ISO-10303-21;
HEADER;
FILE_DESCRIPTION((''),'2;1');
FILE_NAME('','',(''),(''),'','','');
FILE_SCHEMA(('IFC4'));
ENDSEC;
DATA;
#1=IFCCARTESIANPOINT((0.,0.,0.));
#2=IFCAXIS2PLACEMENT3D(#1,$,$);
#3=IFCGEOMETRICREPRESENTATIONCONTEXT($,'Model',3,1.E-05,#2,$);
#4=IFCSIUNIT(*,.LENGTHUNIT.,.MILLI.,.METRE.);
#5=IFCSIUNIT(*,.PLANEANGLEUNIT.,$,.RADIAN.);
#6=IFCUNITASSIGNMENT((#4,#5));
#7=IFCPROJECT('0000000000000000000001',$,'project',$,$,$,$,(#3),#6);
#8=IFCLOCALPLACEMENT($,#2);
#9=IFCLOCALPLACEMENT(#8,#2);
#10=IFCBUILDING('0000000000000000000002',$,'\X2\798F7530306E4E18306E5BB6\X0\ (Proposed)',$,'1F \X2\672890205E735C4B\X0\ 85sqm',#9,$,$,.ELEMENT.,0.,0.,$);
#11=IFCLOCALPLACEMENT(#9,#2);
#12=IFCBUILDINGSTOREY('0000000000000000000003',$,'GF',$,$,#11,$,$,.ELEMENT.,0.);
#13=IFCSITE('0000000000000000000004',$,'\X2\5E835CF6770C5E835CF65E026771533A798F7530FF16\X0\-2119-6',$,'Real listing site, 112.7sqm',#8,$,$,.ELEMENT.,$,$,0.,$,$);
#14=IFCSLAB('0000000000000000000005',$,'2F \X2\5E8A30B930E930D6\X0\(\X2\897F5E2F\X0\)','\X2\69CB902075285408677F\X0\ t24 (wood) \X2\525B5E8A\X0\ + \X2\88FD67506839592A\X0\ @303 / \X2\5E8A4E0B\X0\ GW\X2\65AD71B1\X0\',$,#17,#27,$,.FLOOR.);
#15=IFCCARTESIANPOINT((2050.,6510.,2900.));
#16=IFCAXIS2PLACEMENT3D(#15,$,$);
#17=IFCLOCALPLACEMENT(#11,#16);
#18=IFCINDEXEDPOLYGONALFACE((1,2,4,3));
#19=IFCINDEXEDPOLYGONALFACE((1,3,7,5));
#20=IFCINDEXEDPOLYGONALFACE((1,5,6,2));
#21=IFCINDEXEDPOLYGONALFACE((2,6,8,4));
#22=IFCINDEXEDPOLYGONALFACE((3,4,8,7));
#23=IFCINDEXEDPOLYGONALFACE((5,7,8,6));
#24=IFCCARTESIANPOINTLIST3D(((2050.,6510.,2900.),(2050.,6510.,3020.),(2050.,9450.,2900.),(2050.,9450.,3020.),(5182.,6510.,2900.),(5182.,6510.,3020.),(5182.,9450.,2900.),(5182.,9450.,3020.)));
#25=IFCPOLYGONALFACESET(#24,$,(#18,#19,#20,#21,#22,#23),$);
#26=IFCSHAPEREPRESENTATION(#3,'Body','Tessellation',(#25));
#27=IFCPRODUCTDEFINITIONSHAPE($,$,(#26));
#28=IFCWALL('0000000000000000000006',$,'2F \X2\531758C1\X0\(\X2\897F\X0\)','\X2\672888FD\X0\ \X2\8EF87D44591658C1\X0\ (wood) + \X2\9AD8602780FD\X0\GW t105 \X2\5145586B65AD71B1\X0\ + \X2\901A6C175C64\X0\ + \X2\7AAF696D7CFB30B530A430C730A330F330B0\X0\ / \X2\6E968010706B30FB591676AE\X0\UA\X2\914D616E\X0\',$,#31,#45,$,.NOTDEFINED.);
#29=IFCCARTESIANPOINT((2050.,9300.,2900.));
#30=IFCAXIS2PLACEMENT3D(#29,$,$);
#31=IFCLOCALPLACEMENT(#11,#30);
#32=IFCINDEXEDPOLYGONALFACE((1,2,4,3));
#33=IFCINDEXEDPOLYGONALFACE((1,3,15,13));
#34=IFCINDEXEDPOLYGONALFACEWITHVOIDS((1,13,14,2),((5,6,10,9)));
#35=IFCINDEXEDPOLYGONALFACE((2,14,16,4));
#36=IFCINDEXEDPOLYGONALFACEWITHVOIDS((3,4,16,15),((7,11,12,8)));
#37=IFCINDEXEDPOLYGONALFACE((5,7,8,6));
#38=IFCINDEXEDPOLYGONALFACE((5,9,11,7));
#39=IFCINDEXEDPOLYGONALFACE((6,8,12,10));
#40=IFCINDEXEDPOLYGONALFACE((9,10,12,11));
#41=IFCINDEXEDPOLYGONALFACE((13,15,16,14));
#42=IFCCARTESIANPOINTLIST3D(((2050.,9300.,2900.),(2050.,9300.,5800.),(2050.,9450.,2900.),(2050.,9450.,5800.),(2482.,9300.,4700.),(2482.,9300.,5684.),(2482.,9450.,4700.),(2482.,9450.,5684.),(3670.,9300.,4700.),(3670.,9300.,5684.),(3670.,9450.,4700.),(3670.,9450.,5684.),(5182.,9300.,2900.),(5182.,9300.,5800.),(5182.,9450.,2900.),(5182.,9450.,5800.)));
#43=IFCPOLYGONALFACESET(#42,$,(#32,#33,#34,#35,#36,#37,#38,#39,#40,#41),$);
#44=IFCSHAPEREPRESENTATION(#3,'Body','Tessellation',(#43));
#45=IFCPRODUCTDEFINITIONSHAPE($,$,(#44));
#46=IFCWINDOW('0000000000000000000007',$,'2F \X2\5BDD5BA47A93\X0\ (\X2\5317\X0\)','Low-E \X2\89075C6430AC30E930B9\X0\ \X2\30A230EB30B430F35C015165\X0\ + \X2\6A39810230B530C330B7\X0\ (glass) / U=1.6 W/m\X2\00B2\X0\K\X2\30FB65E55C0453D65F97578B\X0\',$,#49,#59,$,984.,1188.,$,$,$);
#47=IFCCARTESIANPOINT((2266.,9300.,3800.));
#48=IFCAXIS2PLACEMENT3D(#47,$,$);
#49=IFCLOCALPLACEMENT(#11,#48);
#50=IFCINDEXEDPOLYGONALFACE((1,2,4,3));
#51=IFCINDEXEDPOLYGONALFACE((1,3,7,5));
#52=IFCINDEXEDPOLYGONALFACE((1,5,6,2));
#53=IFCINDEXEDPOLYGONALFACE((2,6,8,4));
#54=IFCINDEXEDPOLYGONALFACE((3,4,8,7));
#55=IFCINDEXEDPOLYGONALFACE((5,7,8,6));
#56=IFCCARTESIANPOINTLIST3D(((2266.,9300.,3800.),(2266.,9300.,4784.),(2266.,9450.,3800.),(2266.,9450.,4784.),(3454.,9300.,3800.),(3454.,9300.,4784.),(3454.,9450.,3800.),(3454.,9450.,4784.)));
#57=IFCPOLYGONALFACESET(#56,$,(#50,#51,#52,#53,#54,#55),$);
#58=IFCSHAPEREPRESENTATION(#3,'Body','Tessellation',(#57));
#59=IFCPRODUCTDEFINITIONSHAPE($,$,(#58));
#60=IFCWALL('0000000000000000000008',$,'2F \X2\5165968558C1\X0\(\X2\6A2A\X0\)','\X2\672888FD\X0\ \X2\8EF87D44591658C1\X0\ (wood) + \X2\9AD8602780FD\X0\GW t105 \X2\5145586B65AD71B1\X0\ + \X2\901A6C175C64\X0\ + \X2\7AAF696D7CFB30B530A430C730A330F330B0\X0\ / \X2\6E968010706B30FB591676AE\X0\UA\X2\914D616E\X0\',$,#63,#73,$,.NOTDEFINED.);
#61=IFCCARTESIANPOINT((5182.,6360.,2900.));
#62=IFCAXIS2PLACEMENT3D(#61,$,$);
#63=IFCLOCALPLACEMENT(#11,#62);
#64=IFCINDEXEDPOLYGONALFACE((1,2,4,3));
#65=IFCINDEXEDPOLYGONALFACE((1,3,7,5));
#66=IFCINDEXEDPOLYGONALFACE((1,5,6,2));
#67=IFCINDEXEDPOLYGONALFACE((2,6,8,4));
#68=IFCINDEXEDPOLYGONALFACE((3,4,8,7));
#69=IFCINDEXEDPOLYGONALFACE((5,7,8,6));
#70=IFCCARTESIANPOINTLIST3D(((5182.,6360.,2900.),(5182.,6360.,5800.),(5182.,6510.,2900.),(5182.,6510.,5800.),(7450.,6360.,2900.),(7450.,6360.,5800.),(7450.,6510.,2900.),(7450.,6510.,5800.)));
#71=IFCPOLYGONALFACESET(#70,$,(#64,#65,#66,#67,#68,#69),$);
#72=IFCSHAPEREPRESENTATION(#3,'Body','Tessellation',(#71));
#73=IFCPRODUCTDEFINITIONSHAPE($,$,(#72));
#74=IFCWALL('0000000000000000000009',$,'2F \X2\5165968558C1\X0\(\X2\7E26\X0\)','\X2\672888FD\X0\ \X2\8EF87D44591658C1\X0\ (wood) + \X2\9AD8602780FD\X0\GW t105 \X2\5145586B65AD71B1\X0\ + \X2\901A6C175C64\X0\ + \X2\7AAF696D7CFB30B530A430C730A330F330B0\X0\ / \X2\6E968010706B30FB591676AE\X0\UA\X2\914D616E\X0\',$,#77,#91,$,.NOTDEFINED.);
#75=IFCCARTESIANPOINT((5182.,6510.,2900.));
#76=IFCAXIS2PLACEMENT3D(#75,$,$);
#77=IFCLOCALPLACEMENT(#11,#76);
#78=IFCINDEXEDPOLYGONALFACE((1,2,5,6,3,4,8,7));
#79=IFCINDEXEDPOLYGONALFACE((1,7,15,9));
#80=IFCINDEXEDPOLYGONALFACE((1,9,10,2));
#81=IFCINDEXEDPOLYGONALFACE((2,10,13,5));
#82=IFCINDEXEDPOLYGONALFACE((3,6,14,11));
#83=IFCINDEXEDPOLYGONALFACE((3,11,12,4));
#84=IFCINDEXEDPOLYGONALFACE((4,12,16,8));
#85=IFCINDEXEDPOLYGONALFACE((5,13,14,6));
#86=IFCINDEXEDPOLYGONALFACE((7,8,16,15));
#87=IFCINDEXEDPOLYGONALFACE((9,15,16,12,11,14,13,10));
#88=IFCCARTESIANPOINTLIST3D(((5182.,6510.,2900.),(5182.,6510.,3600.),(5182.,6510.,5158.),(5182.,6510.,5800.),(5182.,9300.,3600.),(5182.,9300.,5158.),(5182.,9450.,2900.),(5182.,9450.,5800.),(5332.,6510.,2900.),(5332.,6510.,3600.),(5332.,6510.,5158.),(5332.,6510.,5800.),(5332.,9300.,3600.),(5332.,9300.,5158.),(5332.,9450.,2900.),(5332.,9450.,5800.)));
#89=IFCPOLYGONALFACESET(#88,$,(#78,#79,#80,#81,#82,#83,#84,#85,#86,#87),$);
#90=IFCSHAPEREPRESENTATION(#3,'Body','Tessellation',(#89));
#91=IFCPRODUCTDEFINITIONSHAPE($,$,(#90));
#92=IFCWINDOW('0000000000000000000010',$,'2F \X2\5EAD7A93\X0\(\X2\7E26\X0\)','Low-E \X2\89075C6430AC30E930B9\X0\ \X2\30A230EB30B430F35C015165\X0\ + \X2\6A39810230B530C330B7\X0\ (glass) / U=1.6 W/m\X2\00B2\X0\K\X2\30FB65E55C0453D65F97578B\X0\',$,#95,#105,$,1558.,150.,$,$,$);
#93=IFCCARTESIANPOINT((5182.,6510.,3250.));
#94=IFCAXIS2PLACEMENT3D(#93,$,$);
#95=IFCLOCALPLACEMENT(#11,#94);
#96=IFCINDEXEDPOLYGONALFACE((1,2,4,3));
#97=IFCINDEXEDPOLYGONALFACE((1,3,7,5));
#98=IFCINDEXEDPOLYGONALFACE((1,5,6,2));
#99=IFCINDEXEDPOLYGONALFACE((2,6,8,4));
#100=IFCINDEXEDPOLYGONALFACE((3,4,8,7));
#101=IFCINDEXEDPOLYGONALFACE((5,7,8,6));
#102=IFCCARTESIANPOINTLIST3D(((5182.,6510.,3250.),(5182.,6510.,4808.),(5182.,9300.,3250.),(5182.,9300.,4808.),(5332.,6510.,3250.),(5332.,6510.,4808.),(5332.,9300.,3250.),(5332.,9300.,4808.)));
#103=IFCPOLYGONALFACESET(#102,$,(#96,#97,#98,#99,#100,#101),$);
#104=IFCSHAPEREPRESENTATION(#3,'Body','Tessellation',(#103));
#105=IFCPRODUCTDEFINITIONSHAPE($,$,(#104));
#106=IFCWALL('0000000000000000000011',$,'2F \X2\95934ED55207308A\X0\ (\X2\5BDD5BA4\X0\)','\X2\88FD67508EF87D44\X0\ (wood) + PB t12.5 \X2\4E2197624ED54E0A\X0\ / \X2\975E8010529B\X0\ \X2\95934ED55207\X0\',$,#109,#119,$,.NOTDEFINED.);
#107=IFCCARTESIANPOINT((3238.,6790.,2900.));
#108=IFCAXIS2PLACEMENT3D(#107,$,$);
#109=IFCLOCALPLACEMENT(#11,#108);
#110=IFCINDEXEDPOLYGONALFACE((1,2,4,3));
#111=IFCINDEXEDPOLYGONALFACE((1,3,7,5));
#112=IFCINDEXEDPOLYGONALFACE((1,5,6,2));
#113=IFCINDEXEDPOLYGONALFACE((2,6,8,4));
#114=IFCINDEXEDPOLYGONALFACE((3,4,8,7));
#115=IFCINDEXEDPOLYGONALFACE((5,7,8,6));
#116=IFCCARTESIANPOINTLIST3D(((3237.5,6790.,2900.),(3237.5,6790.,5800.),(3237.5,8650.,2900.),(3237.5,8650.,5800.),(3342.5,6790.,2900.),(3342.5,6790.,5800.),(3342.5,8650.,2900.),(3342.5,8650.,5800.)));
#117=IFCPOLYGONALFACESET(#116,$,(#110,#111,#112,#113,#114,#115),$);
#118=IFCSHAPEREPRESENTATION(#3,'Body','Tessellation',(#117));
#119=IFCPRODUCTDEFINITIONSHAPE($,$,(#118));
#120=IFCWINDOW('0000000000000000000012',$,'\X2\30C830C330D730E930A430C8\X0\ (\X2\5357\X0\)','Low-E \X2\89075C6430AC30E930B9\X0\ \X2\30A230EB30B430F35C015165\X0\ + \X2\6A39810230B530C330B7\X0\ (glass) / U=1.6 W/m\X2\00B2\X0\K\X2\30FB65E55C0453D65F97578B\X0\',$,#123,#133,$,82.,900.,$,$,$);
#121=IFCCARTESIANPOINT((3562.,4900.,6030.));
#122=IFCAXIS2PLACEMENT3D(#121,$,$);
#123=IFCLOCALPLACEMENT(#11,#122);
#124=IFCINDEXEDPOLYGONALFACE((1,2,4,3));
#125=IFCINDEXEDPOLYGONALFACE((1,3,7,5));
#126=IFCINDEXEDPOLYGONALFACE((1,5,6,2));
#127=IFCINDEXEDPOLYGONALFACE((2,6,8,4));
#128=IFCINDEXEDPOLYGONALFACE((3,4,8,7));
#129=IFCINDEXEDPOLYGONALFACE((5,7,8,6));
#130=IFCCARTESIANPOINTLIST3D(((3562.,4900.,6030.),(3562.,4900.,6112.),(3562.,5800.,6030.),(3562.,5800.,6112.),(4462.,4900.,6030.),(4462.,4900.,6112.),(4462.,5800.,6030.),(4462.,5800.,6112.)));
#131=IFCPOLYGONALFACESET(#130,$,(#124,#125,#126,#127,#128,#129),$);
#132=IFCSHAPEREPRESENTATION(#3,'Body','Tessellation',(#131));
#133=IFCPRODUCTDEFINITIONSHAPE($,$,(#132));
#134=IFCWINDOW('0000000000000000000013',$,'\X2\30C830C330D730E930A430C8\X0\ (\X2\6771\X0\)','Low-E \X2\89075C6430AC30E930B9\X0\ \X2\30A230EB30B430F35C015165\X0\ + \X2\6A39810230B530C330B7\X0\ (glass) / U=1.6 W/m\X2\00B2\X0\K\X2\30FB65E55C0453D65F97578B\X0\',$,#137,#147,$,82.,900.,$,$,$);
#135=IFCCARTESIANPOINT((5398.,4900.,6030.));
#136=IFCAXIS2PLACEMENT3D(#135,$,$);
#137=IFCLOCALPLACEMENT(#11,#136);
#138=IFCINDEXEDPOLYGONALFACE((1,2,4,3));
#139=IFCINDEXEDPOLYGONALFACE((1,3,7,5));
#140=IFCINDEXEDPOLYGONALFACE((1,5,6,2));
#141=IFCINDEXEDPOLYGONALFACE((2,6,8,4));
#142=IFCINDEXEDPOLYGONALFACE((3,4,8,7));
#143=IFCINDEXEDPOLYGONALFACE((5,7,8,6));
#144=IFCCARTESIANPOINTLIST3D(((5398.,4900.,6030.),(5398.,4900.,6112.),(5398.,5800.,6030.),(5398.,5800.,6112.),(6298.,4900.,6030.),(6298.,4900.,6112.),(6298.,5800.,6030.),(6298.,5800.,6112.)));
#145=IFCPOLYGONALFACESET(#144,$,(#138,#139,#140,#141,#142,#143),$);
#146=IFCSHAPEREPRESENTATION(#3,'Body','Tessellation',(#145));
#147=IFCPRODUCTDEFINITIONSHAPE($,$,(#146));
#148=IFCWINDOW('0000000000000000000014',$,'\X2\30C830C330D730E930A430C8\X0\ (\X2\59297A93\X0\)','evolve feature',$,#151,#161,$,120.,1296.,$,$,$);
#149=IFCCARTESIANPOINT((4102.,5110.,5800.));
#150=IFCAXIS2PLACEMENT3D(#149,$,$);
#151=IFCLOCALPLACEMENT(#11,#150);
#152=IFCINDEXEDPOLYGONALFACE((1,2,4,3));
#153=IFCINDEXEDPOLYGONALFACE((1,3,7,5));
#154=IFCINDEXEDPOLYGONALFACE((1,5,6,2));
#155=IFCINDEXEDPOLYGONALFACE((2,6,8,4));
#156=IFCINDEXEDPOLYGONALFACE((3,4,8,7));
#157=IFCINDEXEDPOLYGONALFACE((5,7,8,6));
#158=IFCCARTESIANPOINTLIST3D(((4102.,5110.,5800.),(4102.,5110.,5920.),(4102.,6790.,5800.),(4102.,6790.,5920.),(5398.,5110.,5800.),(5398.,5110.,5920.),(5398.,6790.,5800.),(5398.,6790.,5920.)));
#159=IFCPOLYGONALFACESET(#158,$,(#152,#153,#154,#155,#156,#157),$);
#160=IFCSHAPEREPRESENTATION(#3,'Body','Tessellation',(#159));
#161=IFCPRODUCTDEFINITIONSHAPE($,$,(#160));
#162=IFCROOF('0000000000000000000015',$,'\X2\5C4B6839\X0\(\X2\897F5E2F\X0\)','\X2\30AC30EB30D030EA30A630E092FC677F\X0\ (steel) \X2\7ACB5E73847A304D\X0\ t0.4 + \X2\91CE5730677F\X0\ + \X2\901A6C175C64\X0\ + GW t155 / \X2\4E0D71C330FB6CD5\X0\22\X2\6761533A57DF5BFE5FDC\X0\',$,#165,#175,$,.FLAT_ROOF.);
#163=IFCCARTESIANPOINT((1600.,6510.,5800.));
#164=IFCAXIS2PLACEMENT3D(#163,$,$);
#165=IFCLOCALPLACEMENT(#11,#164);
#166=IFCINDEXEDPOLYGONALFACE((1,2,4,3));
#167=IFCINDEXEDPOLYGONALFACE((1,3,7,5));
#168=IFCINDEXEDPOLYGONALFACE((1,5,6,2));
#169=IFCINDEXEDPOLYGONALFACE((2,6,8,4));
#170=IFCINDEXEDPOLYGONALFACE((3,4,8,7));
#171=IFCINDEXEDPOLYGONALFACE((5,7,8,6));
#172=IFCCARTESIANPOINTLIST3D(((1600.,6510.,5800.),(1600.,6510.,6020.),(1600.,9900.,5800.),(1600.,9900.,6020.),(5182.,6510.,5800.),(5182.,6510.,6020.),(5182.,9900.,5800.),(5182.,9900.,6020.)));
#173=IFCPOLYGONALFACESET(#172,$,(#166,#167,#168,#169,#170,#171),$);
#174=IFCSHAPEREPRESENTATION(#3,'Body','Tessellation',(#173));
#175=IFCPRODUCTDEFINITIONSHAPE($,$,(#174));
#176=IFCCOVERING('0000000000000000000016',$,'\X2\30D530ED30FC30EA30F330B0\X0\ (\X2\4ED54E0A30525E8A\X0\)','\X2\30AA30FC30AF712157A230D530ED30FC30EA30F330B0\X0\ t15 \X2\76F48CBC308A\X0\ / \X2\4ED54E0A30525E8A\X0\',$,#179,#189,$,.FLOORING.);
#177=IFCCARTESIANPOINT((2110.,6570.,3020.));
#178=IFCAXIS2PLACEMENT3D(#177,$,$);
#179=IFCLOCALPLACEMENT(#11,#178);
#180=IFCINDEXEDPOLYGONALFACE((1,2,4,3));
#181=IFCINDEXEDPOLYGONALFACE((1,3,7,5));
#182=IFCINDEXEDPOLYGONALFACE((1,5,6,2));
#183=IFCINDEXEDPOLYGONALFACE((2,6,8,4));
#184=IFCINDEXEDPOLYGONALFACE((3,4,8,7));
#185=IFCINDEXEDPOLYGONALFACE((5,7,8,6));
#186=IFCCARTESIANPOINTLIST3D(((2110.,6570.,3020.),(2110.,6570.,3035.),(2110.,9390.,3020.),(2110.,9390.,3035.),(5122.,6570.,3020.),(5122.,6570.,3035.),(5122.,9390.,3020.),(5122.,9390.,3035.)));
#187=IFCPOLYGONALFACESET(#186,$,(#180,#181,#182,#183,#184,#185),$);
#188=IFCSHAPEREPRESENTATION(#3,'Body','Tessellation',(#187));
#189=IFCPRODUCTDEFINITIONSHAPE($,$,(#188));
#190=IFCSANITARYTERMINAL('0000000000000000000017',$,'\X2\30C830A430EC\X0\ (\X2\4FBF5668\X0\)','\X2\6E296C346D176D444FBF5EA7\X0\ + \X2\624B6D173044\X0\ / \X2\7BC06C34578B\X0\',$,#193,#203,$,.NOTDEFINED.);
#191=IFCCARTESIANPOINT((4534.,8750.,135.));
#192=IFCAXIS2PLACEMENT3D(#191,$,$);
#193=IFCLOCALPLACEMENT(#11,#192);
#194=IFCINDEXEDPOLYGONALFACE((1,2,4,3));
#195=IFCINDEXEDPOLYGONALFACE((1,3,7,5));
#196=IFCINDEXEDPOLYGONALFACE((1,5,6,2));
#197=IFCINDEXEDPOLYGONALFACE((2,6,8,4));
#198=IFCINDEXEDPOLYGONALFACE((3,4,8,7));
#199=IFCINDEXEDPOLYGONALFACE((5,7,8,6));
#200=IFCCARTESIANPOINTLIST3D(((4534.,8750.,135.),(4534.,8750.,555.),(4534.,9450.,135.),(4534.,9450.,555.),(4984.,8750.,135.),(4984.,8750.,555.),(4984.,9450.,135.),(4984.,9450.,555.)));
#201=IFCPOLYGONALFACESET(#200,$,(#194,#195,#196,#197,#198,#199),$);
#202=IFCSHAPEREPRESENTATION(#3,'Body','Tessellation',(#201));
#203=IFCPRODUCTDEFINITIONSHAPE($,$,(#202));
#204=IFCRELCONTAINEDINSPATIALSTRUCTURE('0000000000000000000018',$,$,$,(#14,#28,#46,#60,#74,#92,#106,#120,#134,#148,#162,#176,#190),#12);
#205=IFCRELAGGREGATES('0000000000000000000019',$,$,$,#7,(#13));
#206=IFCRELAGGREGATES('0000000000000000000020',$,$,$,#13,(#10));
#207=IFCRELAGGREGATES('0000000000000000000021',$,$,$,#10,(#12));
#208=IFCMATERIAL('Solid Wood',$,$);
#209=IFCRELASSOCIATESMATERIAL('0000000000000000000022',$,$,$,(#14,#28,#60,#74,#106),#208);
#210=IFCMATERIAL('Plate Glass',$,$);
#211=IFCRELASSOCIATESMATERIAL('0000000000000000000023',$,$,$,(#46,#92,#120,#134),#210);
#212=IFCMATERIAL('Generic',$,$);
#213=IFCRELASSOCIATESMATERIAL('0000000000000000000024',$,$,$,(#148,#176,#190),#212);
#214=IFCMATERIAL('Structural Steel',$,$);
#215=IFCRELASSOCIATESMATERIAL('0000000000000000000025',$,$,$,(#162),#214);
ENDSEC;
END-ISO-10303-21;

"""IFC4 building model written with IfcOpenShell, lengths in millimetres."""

from ifc_helpers import new_model, si_unit, frame, frame_2d, origin, place, context, project, spatial, rectangle, extrude, material, element, fill, save


model = new_model("IFC4")

# Units and contexts
model_context = context("Model", 3, precision=1e-05, world=origin())
ifc_project = project(units=[si_unit("LENGTHUNIT", "METRE", prefix="MILLI"), si_unit("PLANEANGLEUNIT", "RADIAN")], contexts=[model_context])

# Site, building, storey
site_placement = place(None, origin())
site = spatial("IfcSite", under=ifc_project, at=site_placement, Name="広島県広島市東区福田６-2119-6", ObjectType="Real listing site, 112.7sqm", CompositionType="ELEMENT", RefElevation=0.0)
building_placement = place(site_placement, origin())
building = spatial("IfcBuilding", under=site, at=building_placement, Name="福田の丘の家 (Proposed)", ObjectType="1F 木造平屋 85sqm", CompositionType="ELEMENT", ElevationOfRefHeight=0.0, ElevationOfTerrain=0.0)
storey_placement = place(building_placement, origin())
storey = spatial("IfcBuildingStorey", under=building, at=storey_placement, Name="GF", CompositionType="ELEMENT", Elevation=0.0)

# Slab
ifc_material_1 = material(Name="Solid Wood")
slab_placement = place(storey_placement, frame((2050.0, 6510.0, 2900.0)))
element("IfcSlab", 1, at=slab_placement, inside=storey, material=ifc_material_1, Name="2F 床スラブ(西帯)", Description="構造用合板 t24 (wood) 剛床 + 製材根太 @303 / 床下 GW断熱", PredefinedType="FLOOR", context=model_context, shape_type="SweptSolid", body=[
    extrude(rectangle(XDim=3132.0, YDim=2940.0, at=frame_2d((1566.0, 1470.0))), frame((2050.0, 6510.0, 2900.0)), (0.0, 0.0, 1.0), 120.0),
])

# Wall, opening, window
wall_1_placement = place(storey_placement, frame((2050.0, 9300.0, 2900.0)))
wall_1 = element("IfcWall", 2, at=wall_1_placement, inside=storey, material=ifc_material_1, Name="2F 北壁(西)", Description="木製 軸組外壁 (wood) + 高性能GW t105 充填断熱 + 通気層 + 窯業系サイディング / 準耐火・外皮UA配慮", PredefinedType="NOTDEFINED", context=model_context, shape_type="SweptSolid", body=[
    extrude(rectangle(XDim=3132.0, YDim=150.0, at=frame_2d((1566.0, 75.0))), frame((2050.0, 9300.0, 2900.0)), (0.0, 0.0, 1.0), 2900.0),
])
opening_1_placement = place(storey_placement, frame((2266.0, 9300.0, 3800.0)))
opening_1 = element("IfcOpeningElement", 3, at=opening_1_placement, cuts=wall_1, PredefinedType="NOTDEFINED", context=model_context, shape_type="SweptSolid", body=[
    extrude(rectangle(XDim=1188.0, YDim=150.0, at=frame_2d((594.0, 75.0))), frame((2266.0, 9300.0, 3800.0)), (0.0, 0.0, 1.0), 984.0),
])
ifc_material_2 = material(Name="Plate Glass")
window_1_placement = place(storey_placement, frame((2266.0, 9300.0, 3800.0)))
window_1 = element("IfcWindow", 4, at=window_1_placement, inside=storey, material=ifc_material_2, Name="2F 寝室窓 (北)", Description="Low-E 複層ガラス アルゴン封入 + 樹脂サッシ (glass) / U=1.6 W/m²K・日射取得型", OverallHeight=984.0, OverallWidth=1188.0, context=model_context, shape_type="SweptSolid", body=[
    extrude(rectangle(XDim=1188.0, YDim=150.0, at=frame_2d((594.0, 75.0))), frame((2266.0, 9300.0, 3800.0)), (0.0, 0.0, 1.0), 984.0),
])
fill(opening_1, window_1)

# Wall
wall_2_placement = place(storey_placement, frame((5182.0, 6360.0, 2900.0)))
element("IfcWall", 5, at=wall_2_placement, inside=storey, material=ifc_material_1, Name="2F 入隅壁(横)", Description="木製 軸組外壁 (wood) + 高性能GW t105 充填断熱 + 通気層 + 窯業系サイディング / 準耐火・外皮UA配慮", PredefinedType="NOTDEFINED", context=model_context, shape_type="SweptSolid", body=[
    extrude(rectangle(XDim=2268.0, YDim=150.0, at=frame_2d((1134.0, 75.0))), frame((5182.0, 6360.0, 2900.0)), (0.0, 0.0, 1.0), 2900.0),
])

# Wall, opening, window
wall_3_placement = place(storey_placement, frame((5182.0, 6510.0, 2900.0)))
wall_3 = element("IfcWall", 6, at=wall_3_placement, inside=storey, material=ifc_material_1, Name="2F 入隅壁(縦)", Description="木製 軸組外壁 (wood) + 高性能GW t105 充填断熱 + 通気層 + 窯業系サイディング / 準耐火・外皮UA配慮", PredefinedType="NOTDEFINED", context=model_context, shape_type="SweptSolid", body=[
    extrude(rectangle(XDim=150.0, YDim=2940.0, at=frame_2d((75.0, 1470.0))), frame((5182.0, 6510.0, 2900.0)), (0.0, 0.0, 1.0), 2900.0),
])
opening_2_placement = place(storey_placement, frame((5182.0, 6510.0, 3250.0)))
opening_2 = element("IfcOpeningElement", 7, at=opening_2_placement, cuts=wall_3, PredefinedType="NOTDEFINED", context=model_context, shape_type="SweptSolid", body=[
    extrude(rectangle(XDim=150.0, YDim=2790.0, at=frame_2d((75.0, 1395.0))), frame((5182.0, 6510.0, 3250.0)), (0.0, 0.0, 1.0), 1558.0),
])
window_2_placement = place(storey_placement, frame((5182.0, 6510.0, 3250.0)))
window_2 = element("IfcWindow", 8, at=window_2_placement, inside=storey, material=ifc_material_2, Name="2F 庭窓(縦)", Description="Low-E 複層ガラス アルゴン封入 + 樹脂サッシ (glass) / U=1.6 W/m²K・日射取得型", OverallHeight=1558.0, OverallWidth=150.0, context=model_context, shape_type="SweptSolid", body=[
    extrude(rectangle(XDim=150.0, YDim=2790.0, at=frame_2d((75.0, 1395.0))), frame((5182.0, 6510.0, 3250.0)), (0.0, 0.0, 1.0), 1558.0),
])
fill(opening_2, window_2)

# Wall
wall_4_placement = place(storey_placement, frame((3238.0, 6790.0, 2900.0)))
element("IfcWall", 9, at=wall_4_placement, inside=storey, material=ifc_material_1, Name="2F 間仕切り (寝室)", Description="製材軸組 (wood) + PB t12.5 両面仕上 / 非耐力 間仕切", PredefinedType="NOTDEFINED", context=model_context, shape_type="SweptSolid", body=[
    extrude(rectangle(XDim=105.0, YDim=1860.0, at=frame_2d((52.0, 930.0))), frame((3238.0, 6790.0, 2900.0)), (0.0, 0.0, 1.0), 2900.0),
])

# Windows
window_3_placement = place(storey_placement, frame((3562.0, 4900.0, 6030.0)))
element("IfcWindow", 10, at=window_3_placement, inside=storey, material=ifc_material_2, Name="トップライト (南)", Description="Low-E 複層ガラス アルゴン封入 + 樹脂サッシ (glass) / U=1.6 W/m²K・日射取得型", OverallHeight=82.0, OverallWidth=900.0, context=model_context, shape_type="SweptSolid", body=[
    extrude(rectangle(XDim=900.0, YDim=900.0, at=frame_2d((450.0, 450.0))), frame((3562.0, 4900.0, 6030.0)), (0.0, 0.0, 1.0), 82.0),
])
window_4_placement = place(storey_placement, frame((5398.0, 4900.0, 6030.0)))
element("IfcWindow", 11, at=window_4_placement, inside=storey, material=ifc_material_2, Name="トップライト (東)", Description="Low-E 複層ガラス アルゴン封入 + 樹脂サッシ (glass) / U=1.6 W/m²K・日射取得型", OverallHeight=82.0, OverallWidth=900.0, context=model_context, shape_type="SweptSolid", body=[
    extrude(rectangle(XDim=900.0, YDim=900.0, at=frame_2d((450.0, 450.0))), frame((5398.0, 4900.0, 6030.0)), (0.0, 0.0, 1.0), 82.0),
])
ifc_material_3 = material(Name="Generic")
window_5_placement = place(storey_placement, frame((4102.0, 5110.0, 5800.0)))
element("IfcWindow", 12, at=window_5_placement, inside=storey, material=ifc_material_3, Name="トップライト (天窓)", Description="evolve feature", OverallHeight=120.0, OverallWidth=1296.0, context=model_context, shape_type="SweptSolid", body=[
    extrude(rectangle(XDim=1296.0, YDim=1680.0, at=frame_2d((648.0, 840.0))), frame((4102.0, 5110.0, 5800.0)), (0.0, 0.0, 1.0), 120.0),
])

# Roof
ifc_material_4 = material(Name="Structural Steel")
for number, where, name in (
    (13, (1600.0, 6510.0, 5800.0), "屋根(西帯)"),
):
    element("IfcRoof", number, at=place(storey_placement, frame(where)), inside=storey, material=ifc_material_4, Name=name, Description="ガルバリウム鋼板 (steel) 立平葺き t0.4 + 野地板 + 通気層 + GW t155 / 不燃・法22条区域対応", PredefinedType="FLAT_ROOF", context=model_context, shape_type="SweptSolid", body=[
        extrude(rectangle(XDim=3582.0, YDim=3390.0, at=frame_2d((1791.0, 1695.0))), frame((1600.0, 6510.0, 5800.0)), (0.0, 0.0, 1.0), 220.0),
    ])

# Covering
covering_placement = place(storey_placement, frame((2110.0, 6570.0, 3020.0)))
element("IfcCovering", 14, at=covering_placement, inside=storey, material=ifc_material_3, Name="フローリング (仕上げ床)", Description="オーク無垢フローリング t15 直貼り / 仕上げ床", PredefinedType="FLOORING", context=model_context, shape_type="SweptSolid", body=[
    extrude(rectangle(XDim=3012.0, YDim=2820.0, at=frame_2d((1506.0, 1410.0))), frame((2110.0, 6570.0, 3020.0)), (0.0, 0.0, 1.0), 15.0),
])

# Sanitary terminal
sanitary_terminal_placement = place(storey_placement, frame((4534.0, 8750.0, 135.0)))
element("IfcSanitaryTerminal", 15, at=sanitary_terminal_placement, inside=storey, material=ifc_material_3, Name="トイレ (便器)", Description="温水洗浄便座 + 手洗い / 節水型", PredefinedType="NOTDEFINED", context=model_context, shape_type="SweptSolid", body=[
    extrude(rectangle(XDim=450.0, YDim=700.0, at=frame_2d((225.0, 350.0))), frame((4534.0, 8750.0, 135.0)), (0.0, 0.0, 1.0), 420.0),
])

save(model, "model.ifc")
